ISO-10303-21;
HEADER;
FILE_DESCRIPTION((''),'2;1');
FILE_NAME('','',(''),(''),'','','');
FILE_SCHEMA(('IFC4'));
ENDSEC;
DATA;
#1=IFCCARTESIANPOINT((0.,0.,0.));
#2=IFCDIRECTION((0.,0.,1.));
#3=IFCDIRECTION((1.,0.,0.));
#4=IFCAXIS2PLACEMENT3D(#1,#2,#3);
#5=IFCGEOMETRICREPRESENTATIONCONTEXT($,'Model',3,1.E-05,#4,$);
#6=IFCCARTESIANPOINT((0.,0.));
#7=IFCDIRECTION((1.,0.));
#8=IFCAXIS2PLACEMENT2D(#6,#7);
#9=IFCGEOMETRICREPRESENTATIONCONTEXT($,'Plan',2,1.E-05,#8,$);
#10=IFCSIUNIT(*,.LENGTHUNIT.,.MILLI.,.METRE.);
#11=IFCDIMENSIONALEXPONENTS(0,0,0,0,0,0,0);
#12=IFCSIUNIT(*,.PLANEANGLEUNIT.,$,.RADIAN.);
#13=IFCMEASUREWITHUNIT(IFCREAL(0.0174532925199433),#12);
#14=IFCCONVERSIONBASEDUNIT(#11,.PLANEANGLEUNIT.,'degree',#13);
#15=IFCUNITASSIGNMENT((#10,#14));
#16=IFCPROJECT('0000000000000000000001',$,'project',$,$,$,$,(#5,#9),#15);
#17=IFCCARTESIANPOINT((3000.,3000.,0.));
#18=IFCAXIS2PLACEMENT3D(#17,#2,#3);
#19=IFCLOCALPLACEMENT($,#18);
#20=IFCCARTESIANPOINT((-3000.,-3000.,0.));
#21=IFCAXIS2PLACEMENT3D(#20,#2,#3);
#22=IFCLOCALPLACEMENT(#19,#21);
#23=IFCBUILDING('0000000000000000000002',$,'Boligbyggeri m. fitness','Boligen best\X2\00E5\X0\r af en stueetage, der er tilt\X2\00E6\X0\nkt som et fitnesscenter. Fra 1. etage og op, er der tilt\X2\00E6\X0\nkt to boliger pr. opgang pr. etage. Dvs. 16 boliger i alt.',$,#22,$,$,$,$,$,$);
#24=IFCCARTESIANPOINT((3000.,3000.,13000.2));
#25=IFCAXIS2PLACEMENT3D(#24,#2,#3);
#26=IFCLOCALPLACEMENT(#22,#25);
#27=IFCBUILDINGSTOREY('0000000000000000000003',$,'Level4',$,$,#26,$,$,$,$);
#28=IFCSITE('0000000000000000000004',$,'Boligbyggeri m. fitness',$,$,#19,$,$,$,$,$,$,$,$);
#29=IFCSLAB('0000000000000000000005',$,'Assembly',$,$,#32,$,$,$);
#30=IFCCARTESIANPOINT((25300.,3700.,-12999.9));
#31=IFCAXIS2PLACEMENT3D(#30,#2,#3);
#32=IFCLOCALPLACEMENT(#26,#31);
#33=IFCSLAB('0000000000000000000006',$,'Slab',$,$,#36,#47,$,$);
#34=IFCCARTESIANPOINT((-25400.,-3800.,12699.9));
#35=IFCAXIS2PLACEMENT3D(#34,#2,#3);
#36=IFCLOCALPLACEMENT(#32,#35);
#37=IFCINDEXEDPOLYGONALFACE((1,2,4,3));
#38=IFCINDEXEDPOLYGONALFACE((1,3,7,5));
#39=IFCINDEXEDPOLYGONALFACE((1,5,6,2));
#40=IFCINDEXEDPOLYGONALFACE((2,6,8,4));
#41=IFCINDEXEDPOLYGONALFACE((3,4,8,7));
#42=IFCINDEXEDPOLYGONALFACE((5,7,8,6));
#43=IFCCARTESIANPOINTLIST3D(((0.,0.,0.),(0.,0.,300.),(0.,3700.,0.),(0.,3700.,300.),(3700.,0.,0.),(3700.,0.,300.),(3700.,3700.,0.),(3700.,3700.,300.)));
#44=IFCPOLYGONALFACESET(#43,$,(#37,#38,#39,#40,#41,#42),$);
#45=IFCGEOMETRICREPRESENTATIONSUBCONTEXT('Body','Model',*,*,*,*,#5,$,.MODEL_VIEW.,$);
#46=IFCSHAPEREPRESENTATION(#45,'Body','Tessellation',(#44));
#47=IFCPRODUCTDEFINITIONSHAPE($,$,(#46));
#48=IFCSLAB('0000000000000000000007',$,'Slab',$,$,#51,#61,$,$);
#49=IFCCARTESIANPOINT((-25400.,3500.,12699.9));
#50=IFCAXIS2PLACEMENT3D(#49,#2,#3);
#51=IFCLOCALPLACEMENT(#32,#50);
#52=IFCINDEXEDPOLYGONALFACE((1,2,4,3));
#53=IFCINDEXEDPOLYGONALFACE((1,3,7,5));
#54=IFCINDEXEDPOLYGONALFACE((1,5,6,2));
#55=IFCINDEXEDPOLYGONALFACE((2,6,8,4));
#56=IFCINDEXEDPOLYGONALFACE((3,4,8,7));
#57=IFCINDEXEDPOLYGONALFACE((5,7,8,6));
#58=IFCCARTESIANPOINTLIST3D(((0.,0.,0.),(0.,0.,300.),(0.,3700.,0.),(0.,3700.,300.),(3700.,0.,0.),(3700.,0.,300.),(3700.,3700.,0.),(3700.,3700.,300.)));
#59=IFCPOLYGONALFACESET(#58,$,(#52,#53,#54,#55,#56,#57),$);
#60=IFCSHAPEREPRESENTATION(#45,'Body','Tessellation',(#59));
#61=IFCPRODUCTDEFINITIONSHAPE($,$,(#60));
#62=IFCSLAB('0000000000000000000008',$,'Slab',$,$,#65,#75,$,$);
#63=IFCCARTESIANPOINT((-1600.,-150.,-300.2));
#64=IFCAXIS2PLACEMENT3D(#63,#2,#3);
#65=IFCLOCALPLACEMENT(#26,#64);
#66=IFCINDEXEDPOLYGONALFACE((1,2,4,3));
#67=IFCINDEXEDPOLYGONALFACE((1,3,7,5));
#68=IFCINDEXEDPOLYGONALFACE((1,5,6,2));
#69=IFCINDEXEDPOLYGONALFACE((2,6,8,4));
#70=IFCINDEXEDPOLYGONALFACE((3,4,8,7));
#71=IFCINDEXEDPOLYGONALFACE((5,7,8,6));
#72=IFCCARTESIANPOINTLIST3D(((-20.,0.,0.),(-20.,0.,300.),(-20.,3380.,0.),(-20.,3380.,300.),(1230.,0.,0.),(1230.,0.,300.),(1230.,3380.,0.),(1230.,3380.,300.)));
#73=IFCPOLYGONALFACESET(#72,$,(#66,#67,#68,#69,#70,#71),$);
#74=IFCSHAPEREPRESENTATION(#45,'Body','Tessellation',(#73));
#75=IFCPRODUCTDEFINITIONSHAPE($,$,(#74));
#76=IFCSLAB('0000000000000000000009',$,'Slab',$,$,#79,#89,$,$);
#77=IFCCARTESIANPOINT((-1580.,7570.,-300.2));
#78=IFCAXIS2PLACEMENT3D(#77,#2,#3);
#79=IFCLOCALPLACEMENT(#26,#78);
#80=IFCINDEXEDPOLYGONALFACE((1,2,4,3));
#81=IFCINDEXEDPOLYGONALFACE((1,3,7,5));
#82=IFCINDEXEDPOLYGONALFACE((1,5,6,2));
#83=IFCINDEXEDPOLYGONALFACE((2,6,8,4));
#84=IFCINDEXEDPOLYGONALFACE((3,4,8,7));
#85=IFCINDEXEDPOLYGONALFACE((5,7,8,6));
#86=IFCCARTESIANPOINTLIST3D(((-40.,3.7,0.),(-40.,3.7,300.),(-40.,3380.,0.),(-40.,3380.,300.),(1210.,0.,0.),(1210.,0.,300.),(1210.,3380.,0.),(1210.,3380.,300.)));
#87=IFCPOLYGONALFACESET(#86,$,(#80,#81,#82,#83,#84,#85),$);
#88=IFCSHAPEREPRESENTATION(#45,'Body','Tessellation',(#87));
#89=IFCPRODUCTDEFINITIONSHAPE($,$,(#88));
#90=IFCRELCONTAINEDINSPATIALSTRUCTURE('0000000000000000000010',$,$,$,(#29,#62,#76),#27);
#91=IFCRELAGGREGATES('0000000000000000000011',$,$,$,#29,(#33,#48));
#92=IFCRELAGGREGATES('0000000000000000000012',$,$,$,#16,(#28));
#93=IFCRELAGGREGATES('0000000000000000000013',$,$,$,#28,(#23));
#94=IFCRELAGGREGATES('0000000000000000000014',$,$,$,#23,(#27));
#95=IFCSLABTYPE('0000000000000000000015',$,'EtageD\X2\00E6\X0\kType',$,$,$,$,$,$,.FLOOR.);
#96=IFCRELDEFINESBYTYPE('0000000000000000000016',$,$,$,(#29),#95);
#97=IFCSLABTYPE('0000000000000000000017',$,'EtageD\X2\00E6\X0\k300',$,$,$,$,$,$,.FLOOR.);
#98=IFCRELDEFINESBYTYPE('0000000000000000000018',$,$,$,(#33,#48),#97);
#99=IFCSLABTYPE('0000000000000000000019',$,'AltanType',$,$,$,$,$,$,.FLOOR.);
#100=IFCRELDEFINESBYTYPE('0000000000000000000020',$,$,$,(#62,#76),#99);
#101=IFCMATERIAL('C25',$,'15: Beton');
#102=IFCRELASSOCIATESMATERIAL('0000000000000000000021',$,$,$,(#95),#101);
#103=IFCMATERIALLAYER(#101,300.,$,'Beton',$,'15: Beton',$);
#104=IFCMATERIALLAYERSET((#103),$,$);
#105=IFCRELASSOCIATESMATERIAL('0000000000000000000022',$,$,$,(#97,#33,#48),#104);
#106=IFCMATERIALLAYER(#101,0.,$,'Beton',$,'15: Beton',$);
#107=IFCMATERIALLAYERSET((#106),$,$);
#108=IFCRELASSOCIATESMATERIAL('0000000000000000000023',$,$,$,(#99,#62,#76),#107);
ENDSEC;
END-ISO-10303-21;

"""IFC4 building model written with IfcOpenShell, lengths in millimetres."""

from ifc_helpers import new_model, entity, si_unit, converted_unit, frame, origin_with_axes, origin_2d_with_axis, place, context, subcontext, project, spatial, line, indexed_curve, outline, extrude, material, layer, layer_set, layer_usage, type_object, element, aggregate, save


model = new_model("IFC4")

# Units and contexts
model_context = context("Model", 3, precision=1e-05, world=origin_with_axes())
plan_context = context("Plan", 2, precision=1e-05, world=origin_2d_with_axis())
body_context = subcontext(model_context, "Body", "Model", "MODEL_VIEW")
ifc_project = project(units=[si_unit("LENGTHUNIT", "METRE", prefix="MILLI"), converted_unit("PLANEANGLEUNIT", "degree", entity("IfcReal", 0.0174532925199433), si_unit("PLANEANGLEUNIT", "RADIAN"), dimensions=[0, 0, 0, 0, 0, 0, 0])], contexts=[model_context, plan_context])

# Site, building, storey
site_placement = place(None, frame((3000.0, 3000.0, 0.0), z_axis=(0.0, 0.0, 1.0), x_axis=(1.0, 0.0, 0.0)))
site = spatial("IfcSite", under=ifc_project, at=site_placement, Name="Boligbyggeri m. fitness")
building_placement = place(site_placement, frame((-3000.0, -3000.0, 0.0), z_axis=(0.0, 0.0, 1.0), x_axis=(1.0, 0.0, 0.0)))
building = spatial("IfcBuilding", under=site, at=building_placement, Name="Boligbyggeri m. fitness", Description="Boligen består af en stueetage, der er tiltænkt som et fitnesscenter. Fra 1. etage og op, er der tiltænkt to boliger pr. opgang pr. etage. Dvs. 16 boliger i alt.")
storey_placement = place(building_placement, frame((3000.0, 3000.0, 13000.2), z_axis=(0.0, 0.0, 1.0), x_axis=(1.0, 0.0, 0.0)))
storey = spatial("IfcBuildingStorey", under=building, at=storey_placement, Name="Level4")

# Shared definitions
ifc_material_1 = material(Name="C25", Category="15: Beton")

# Slabs
slab_type_1 = type_object("IfcSlabType", Name="EtageDækType", PredefinedType="FLOOR", material=ifc_material_1)
slab_1_placement = place(storey_placement, frame((25300.0, 3700.0, -12999.9), z_axis=(0.0, 0.0, 1.0), x_axis=(1.0, 0.0, 0.0)))
slab_1 = element("IfcSlab", 1, at=slab_1_placement, inside=storey, type_object=slab_type_1, Name="Assembly")
ifc_layer_1 = layer(ifc_material_1, 300.0, Name="Beton", Category="15: Beton")
ifc_layer_set_1 = layer_set([ifc_layer_1])
ifc_layer_usage_1 = layer_usage(ifc_layer_set_1, "AXIS3", "POSITIVE", 0.0)
slab_type_2 = type_object("IfcSlabType", Name="EtageDæk300", PredefinedType="FLOOR", material=ifc_layer_set_1)
slab_2_placement = place(slab_1_placement, frame((-25400.0, -3800.0, 12699.9), z_axis=(0.0, 0.0, 1.0), x_axis=(1.0, 0.0, 0.0)))
slab_2 = element("IfcSlab", 2, at=slab_2_placement, type_object=slab_type_2, material=ifc_layer_usage_1, Name="Slab", context=body_context, shape_type="SweptSolid", body=[
    extrude(outline(indexed_curve([(0.0, 0.0), (3700.0, 0.0), (3700.0, 3700.0), (0.0, 3700.0)], segments=[line(3, 2), line(2, 1), line(1, 4), line(4, 3)], self_intersect=False)), None, (0.0, 0.0, 1.0), 300.0),
])
ifc_layer_usage_2 = layer_usage(ifc_layer_set_1, "AXIS3", "POSITIVE", 0.0)
slab_3_placement = place(slab_1_placement, frame((-25400.0, 3500.0, 12699.9), z_axis=(0.0, 0.0, 1.0), x_axis=(1.0, 0.0, 0.0)))
slab_3 = element("IfcSlab", 3, at=slab_3_placement, type_object=slab_type_2, material=ifc_layer_usage_2, Name="Slab", context=body_context, shape_type="SweptSolid", body=[
    extrude(outline(indexed_curve([(0.0, 0.0), (3700.0, 0.0), (3700.0, 3700.0), (0.0, 3700.0)], segments=[line(3, 2), line(2, 1), line(1, 4), line(4, 3)], self_intersect=False)), None, (0.0, 0.0, 1.0), 300.0),
])
aggregate(slab_1, [slab_2, slab_3])
ifc_layer_2 = layer(ifc_material_1, 0.0, Name="Beton", Category="15: Beton")
ifc_layer_set_2 = layer_set([ifc_layer_2])
ifc_layer_usage_3 = layer_usage(ifc_layer_set_2, "AXIS3", "POSITIVE", 0.0)
slab_type_3 = type_object("IfcSlabType", Name="AltanType", PredefinedType="FLOOR", material=ifc_layer_set_2)
slab_4_placement = place(storey_placement, frame((-1600.0, -150.0, -300.2), z_axis=(0.0, 0.0, 1.0), x_axis=(1.0, 0.0, 0.0)))
element("IfcSlab", 4, at=slab_4_placement, inside=storey, type_object=slab_type_3, material=ifc_layer_usage_3, Name="Slab", context=body_context, shape_type="SweptSolid", body=[
    extrude(outline(indexed_curve([(1230.0, 3380.0), (1230.0, 0.0), (-20.0, 0.0), (-20.0, 3380.0)], segments=[line(3, 2), line(2, 1), line(1, 4), line(4, 3)], self_intersect=False)), None, (0.0, 0.0, 1.0), 300.0),
])
ifc_layer_usage_4 = layer_usage(ifc_layer_set_2, "AXIS3", "POSITIVE", 0.0)
slab_5_placement = place(storey_placement, frame((-1580.0, 7570.0, -300.2), z_axis=(0.0, 0.0, 1.0), x_axis=(1.0, 0.0, 0.0)))
element("IfcSlab", 5, at=slab_5_placement, inside=storey, type_object=slab_type_3, material=ifc_layer_usage_4, Name="Slab", context=body_context, shape_type="SweptSolid", body=[
    extrude(outline(indexed_curve([(1210.0, 3380.0), (1210.0, 0.0), (-40.0, 3.7), (-40.0, 3380.0)], segments=[line(3, 2), line(2, 1), line(1, 4), line(4, 3)], self_intersect=False)), None, (0.0, 0.0, 1.0), 300.0),
])

save(model, "model.ifc")
